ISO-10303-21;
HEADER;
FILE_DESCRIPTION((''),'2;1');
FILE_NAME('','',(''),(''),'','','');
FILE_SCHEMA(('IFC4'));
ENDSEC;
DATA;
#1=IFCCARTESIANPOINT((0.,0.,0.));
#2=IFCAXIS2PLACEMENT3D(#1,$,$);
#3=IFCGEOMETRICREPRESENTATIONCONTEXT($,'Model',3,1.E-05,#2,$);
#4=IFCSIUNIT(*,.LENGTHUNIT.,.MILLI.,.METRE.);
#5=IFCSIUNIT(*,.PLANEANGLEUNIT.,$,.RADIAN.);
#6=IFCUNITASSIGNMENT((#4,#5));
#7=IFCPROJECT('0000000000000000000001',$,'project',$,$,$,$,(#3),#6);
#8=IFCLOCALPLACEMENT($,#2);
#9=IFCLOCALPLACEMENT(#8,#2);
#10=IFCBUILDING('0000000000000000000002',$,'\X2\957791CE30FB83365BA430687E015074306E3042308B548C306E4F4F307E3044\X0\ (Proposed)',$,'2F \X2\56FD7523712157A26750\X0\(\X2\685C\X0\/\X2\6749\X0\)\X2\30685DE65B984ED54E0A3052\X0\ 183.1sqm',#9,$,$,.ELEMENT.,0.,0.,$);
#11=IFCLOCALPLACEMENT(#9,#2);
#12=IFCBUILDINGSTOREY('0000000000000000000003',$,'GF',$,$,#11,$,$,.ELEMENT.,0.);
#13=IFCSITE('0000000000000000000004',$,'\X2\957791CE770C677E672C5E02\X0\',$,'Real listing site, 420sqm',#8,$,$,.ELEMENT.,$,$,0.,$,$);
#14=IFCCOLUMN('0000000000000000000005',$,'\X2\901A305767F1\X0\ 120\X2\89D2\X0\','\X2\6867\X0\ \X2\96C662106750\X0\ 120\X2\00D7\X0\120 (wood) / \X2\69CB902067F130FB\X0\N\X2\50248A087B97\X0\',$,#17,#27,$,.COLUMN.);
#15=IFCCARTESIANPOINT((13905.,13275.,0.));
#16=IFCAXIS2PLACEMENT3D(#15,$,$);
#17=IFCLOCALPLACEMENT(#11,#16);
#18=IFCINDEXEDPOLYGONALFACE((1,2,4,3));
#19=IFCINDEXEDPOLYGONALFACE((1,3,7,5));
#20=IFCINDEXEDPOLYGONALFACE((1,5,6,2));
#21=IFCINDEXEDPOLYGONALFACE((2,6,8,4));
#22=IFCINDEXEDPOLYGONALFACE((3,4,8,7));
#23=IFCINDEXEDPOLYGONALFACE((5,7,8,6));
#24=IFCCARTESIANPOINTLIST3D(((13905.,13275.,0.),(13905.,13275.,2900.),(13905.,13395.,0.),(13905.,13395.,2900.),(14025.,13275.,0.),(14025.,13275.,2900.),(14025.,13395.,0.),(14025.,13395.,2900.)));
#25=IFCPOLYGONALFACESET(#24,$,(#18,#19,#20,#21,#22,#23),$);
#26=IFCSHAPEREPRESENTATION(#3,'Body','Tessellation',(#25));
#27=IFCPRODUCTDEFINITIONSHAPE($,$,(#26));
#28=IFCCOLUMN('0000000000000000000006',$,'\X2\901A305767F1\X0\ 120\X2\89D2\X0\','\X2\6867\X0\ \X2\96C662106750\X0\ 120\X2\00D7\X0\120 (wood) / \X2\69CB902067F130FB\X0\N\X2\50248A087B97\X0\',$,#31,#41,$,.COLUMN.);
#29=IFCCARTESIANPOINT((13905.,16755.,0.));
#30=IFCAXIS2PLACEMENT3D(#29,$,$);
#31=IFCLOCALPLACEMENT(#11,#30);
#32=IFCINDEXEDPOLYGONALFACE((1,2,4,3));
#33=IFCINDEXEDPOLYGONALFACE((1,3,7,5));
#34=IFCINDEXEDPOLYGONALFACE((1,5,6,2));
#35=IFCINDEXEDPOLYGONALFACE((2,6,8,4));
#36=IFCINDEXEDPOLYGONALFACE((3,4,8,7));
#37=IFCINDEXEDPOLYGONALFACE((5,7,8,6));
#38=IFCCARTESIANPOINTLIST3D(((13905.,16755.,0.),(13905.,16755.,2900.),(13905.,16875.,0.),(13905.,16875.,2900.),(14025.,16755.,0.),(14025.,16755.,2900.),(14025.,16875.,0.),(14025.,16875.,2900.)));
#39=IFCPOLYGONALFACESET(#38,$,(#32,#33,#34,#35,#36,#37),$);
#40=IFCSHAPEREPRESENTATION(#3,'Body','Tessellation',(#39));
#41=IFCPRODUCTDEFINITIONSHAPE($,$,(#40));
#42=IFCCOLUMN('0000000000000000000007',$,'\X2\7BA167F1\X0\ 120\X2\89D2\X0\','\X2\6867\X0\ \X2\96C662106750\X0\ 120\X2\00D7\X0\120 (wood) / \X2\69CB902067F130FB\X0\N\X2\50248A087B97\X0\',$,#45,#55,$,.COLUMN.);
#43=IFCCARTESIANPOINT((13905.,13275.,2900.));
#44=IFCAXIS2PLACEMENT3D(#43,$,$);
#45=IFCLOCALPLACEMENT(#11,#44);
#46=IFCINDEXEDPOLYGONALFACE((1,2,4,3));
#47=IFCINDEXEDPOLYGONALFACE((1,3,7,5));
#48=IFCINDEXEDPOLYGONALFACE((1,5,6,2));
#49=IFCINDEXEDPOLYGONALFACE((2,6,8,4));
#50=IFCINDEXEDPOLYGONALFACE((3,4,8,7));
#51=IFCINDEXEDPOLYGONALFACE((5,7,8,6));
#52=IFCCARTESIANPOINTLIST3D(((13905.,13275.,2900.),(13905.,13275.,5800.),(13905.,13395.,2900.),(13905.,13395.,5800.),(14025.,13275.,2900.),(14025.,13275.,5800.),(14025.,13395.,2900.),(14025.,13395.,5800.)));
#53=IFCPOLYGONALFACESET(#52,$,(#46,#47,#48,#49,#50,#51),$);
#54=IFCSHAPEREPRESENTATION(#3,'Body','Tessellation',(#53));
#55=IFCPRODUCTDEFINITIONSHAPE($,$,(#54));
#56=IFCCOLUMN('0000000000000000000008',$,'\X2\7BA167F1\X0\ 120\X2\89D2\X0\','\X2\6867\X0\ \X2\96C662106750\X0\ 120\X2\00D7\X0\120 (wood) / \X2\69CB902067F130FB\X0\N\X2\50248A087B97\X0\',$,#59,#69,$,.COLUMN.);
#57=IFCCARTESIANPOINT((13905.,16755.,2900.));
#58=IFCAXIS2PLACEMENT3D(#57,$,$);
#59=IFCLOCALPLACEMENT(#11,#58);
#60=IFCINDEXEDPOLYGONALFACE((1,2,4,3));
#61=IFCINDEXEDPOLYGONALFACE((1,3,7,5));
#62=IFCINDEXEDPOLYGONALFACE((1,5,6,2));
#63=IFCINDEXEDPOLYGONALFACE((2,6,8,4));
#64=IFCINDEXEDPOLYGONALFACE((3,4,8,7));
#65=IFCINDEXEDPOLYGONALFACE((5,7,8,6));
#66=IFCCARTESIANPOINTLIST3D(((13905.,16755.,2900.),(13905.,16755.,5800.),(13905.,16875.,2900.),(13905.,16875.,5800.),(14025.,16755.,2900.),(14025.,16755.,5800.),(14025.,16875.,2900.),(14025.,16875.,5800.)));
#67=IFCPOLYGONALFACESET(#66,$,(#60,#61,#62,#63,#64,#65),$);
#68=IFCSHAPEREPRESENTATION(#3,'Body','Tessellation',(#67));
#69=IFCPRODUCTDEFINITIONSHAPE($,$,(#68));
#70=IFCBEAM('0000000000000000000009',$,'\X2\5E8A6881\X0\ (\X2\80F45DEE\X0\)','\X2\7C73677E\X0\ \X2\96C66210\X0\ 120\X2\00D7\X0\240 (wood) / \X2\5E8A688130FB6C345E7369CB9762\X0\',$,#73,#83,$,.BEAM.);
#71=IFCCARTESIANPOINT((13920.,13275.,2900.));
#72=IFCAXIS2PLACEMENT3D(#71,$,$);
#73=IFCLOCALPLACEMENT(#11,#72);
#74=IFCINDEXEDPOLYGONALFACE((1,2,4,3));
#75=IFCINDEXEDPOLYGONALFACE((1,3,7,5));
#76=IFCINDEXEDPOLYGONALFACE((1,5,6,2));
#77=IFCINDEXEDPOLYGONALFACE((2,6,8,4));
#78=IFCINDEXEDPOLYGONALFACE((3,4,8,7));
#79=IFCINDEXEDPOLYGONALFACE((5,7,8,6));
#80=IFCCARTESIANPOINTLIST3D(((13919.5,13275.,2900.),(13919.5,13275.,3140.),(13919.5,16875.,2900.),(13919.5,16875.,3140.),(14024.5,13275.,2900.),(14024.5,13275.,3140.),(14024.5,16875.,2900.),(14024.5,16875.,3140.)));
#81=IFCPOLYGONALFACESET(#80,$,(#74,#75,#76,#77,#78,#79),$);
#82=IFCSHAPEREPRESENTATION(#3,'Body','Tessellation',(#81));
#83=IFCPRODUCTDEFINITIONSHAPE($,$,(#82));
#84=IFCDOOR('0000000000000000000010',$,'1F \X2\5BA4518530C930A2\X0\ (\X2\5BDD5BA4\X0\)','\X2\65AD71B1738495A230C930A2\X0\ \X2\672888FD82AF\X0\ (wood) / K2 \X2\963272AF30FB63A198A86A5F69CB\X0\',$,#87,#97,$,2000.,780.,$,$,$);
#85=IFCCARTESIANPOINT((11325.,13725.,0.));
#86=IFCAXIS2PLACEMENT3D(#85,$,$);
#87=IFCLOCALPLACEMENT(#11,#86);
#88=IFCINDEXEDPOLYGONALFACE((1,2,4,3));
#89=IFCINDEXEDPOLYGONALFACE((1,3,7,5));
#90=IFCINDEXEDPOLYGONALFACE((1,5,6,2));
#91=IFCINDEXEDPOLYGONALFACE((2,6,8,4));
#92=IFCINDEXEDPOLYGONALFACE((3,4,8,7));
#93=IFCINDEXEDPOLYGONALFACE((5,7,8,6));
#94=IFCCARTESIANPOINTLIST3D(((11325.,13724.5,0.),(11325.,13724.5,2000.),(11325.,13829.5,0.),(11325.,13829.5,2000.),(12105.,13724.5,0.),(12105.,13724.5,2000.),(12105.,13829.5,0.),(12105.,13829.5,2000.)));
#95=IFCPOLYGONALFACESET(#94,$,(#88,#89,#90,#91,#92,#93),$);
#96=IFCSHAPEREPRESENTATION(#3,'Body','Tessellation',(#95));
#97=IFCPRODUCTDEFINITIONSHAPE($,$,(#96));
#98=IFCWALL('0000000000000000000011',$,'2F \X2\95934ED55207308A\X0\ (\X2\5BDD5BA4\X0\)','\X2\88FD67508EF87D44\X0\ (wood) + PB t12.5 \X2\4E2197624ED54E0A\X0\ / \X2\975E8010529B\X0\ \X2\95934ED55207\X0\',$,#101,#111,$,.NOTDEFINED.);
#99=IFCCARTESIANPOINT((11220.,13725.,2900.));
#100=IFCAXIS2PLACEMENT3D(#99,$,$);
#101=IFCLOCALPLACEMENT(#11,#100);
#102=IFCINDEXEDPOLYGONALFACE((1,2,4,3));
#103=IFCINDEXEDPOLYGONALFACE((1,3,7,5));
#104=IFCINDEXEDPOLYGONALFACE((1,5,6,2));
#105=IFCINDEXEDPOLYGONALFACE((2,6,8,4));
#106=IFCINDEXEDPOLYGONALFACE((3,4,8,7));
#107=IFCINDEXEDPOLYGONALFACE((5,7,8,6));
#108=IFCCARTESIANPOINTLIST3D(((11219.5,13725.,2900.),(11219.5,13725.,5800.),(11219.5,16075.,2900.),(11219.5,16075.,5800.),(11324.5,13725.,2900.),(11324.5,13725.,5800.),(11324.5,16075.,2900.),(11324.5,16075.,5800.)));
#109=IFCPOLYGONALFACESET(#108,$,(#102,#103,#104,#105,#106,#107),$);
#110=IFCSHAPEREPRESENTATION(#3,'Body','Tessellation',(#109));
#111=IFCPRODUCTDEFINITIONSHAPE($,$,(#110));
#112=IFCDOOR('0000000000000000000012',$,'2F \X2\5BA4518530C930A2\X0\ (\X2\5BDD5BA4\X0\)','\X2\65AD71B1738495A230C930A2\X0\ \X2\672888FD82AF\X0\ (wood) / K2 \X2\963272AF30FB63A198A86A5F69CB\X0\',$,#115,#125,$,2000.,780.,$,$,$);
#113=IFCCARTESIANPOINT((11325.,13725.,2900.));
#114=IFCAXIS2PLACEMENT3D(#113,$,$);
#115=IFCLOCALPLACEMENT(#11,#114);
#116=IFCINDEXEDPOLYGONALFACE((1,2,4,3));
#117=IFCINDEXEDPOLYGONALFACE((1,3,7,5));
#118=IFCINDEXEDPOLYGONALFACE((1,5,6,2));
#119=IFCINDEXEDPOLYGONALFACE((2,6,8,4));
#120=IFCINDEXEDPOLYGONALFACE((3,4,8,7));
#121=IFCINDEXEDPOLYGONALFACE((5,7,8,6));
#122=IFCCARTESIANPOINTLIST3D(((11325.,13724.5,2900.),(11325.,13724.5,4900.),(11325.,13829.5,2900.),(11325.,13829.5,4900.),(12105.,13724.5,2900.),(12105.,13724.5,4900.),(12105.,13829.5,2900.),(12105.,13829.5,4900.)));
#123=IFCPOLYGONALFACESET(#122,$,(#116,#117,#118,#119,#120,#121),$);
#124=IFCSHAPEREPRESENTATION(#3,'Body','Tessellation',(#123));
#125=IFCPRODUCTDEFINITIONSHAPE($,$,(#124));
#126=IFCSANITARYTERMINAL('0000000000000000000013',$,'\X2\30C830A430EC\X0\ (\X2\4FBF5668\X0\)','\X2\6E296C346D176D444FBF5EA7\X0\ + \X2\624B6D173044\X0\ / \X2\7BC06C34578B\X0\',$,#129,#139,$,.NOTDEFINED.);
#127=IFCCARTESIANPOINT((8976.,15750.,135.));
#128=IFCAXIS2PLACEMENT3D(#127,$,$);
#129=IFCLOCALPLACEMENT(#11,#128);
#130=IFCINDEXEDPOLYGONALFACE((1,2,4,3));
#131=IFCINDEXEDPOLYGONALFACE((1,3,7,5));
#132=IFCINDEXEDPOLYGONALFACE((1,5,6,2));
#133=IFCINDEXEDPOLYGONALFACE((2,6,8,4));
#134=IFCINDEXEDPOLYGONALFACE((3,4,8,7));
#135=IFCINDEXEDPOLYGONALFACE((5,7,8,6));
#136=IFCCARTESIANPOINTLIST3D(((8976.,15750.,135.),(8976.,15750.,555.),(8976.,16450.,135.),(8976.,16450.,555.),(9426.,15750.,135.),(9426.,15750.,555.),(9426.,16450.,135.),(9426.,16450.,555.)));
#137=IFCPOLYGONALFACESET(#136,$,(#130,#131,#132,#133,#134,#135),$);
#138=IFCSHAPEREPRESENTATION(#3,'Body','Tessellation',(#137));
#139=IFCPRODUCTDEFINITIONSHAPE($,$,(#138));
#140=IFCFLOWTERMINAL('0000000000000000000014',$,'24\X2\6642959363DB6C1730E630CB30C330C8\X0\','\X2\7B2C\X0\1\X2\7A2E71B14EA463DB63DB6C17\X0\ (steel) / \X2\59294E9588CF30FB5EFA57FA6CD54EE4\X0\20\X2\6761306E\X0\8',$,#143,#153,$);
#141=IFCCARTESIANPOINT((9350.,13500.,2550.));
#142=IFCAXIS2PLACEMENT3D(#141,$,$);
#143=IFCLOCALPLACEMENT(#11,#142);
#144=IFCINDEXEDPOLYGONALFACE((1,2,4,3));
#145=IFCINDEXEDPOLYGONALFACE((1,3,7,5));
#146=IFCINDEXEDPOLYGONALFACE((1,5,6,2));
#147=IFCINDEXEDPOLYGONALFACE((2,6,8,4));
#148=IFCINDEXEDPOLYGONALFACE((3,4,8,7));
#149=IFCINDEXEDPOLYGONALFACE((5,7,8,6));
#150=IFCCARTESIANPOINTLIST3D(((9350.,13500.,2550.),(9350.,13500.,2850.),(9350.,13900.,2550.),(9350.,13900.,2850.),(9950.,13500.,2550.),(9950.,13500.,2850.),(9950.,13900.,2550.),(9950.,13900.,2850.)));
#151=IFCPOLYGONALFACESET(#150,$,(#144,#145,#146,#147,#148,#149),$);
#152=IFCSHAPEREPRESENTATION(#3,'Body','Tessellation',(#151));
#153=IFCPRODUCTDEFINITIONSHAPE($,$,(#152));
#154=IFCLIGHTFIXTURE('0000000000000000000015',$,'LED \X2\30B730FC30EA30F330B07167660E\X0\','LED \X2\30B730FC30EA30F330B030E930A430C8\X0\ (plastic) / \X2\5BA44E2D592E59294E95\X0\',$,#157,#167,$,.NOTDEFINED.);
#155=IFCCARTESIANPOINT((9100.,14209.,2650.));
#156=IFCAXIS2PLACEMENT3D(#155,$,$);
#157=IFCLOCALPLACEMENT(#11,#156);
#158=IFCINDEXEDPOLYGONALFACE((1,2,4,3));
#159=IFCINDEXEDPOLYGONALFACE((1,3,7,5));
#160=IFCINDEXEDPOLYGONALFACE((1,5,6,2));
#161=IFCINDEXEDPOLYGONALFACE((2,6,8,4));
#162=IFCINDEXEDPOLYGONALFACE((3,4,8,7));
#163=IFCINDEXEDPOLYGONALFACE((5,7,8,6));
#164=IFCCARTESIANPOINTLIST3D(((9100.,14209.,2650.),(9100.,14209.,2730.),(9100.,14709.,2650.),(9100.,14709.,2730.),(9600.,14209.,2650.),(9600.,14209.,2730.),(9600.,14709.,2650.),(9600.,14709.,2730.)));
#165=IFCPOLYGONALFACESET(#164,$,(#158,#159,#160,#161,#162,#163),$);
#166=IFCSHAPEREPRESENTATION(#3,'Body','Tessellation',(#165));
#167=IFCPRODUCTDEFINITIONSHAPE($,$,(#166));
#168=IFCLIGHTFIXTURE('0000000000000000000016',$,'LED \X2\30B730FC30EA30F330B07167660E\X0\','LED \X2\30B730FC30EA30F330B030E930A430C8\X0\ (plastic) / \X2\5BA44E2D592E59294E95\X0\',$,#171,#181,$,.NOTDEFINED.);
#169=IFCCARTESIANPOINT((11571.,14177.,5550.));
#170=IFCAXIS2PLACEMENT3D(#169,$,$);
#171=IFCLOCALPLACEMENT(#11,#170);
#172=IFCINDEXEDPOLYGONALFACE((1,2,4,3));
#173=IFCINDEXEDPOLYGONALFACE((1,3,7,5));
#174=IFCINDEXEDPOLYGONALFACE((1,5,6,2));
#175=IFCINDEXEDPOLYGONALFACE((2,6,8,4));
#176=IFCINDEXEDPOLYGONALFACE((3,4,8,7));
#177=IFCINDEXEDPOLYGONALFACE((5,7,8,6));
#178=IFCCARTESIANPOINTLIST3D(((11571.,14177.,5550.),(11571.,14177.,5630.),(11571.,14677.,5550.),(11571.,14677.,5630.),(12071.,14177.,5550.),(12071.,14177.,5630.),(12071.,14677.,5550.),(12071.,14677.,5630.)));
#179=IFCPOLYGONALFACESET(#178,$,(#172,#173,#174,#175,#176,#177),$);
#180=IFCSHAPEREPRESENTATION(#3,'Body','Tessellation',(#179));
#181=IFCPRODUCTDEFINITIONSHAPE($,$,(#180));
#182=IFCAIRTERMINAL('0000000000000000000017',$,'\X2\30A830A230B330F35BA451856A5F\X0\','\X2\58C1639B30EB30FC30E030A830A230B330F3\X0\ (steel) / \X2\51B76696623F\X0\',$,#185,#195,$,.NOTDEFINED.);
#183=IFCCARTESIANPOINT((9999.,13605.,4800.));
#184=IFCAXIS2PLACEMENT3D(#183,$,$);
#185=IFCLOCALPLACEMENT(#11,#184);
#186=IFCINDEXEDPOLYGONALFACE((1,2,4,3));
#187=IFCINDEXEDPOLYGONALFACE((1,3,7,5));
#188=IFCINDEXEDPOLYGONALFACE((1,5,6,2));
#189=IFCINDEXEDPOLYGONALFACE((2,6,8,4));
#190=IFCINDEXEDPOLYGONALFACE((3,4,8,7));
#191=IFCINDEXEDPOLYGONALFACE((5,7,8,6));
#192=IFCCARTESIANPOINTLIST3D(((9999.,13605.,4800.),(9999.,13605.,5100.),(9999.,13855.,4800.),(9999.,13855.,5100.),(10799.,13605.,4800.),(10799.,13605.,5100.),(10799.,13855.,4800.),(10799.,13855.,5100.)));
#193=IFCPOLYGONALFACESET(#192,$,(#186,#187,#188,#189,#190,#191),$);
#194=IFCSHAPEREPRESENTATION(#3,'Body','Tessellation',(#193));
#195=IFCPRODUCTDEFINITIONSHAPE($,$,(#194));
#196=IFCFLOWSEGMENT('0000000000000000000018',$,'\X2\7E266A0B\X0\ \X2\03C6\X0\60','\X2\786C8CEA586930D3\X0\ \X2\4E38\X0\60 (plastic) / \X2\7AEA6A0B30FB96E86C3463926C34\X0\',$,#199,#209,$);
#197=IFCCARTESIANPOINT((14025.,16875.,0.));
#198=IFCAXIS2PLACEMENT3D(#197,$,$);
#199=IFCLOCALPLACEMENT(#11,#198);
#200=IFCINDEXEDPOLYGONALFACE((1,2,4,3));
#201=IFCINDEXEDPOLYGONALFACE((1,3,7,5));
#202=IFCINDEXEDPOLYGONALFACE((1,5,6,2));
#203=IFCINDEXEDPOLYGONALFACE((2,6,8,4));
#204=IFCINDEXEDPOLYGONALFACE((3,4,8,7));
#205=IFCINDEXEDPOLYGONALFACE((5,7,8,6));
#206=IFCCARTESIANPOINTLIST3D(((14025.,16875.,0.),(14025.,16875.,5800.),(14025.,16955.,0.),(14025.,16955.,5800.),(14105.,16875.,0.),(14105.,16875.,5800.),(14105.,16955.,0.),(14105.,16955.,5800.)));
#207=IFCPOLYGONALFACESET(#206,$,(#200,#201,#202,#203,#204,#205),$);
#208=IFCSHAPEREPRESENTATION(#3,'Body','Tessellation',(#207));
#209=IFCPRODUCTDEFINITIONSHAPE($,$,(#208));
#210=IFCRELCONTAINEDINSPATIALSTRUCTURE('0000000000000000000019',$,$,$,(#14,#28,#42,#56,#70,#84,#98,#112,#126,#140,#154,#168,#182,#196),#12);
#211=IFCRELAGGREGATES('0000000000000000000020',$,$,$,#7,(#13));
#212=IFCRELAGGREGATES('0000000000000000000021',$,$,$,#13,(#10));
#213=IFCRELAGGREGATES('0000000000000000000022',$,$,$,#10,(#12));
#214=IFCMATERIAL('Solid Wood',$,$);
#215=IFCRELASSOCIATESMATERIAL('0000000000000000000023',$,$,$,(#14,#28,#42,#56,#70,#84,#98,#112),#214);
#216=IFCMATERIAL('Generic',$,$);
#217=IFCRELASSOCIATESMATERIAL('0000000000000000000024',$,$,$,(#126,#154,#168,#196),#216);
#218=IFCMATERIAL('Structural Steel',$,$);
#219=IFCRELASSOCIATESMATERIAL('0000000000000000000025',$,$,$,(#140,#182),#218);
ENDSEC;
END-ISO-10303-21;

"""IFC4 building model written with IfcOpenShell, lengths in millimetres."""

from ifc_helpers import new_model, si_unit, frame, frame_2d, origin, place, context, project, spatial, rectangle, extrude, material, element, save


model = new_model("IFC4")

# Units and contexts
model_context = context("Model", 3, precision=1e-05, world=origin())
ifc_project = project(units=[si_unit("LENGTHUNIT", "METRE", prefix="MILLI"), si_unit("PLANEANGLEUNIT", "RADIAN")], contexts=[model_context])

# Site, building, storey
site_placement = place(None, origin())
site = spatial("IfcSite", under=ifc_project, at=site_placement, Name="長野県松本市", ObjectType="Real listing site, 420sqm", CompositionType="ELEMENT", RefElevation=0.0)
building_placement = place(site_placement, origin())
building = spatial("IfcBuilding", under=site, at=building_placement, Name="長野・茶室と縁側のある和の住まい (Proposed)", ObjectType="2F 国産無垢材(桜/杉)と左官仕上げ 183.1sqm", CompositionType="ELEMENT", ElevationOfRefHeight=0.0, ElevationOfTerrain=0.0)
storey_placement = place(building_placement, origin())
storey = spatial("IfcBuildingStorey", under=building, at=storey_placement, Name="GF", CompositionType="ELEMENT", Elevation=0.0)

# Columns
ifc_material_1 = material(Name="Solid Wood")
column_1_placement = place(storey_placement, frame((13905.0, 13275.0, 0.0)))
element("IfcColumn", 1, at=column_1_placement, inside=storey, material=ifc_material_1, Name="通し柱 120角", Description="桧 集成材 120×120 (wood) / 構造柱・N値計算", PredefinedType="COLUMN", context=model_context, shape_type="SweptSolid", body=[
    extrude(rectangle(XDim=120.0, YDim=120.0, at=frame_2d((60.0, 60.0))), frame((13905.0, 13275.0, 0.0)), (0.0, 0.0, 1.0), 2900.0),
])
column_2_placement = place(storey_placement, frame((13905.0, 16755.0, 0.0)))
element("IfcColumn", 2, at=column_2_placement, inside=storey, material=ifc_material_1, Name="通し柱 120角", Description="桧 集成材 120×120 (wood) / 構造柱・N値計算", PredefinedType="COLUMN", context=model_context, shape_type="SweptSolid", body=[
    extrude(rectangle(XDim=120.0, YDim=120.0, at=frame_2d((60.0, 60.0))), frame((13905.0, 16755.0, 0.0)), (0.0, 0.0, 1.0), 2900.0),
])
column_3_placement = place(storey_placement, frame((13905.0, 13275.0, 2900.0)))
element("IfcColumn", 3, at=column_3_placement, inside=storey, material=ifc_material_1, Name="管柱 120角", Description="桧 集成材 120×120 (wood) / 構造柱・N値計算", PredefinedType="COLUMN", context=model_context, shape_type="SweptSolid", body=[
    extrude(rectangle(XDim=120.0, YDim=120.0, at=frame_2d((60.0, 60.0))), frame((13905.0, 13275.0, 2900.0)), (0.0, 0.0, 1.0), 2900.0),
])
column_4_placement = place(storey_placement, frame((13905.0, 16755.0, 2900.0)))
element("IfcColumn", 4, at=column_4_placement, inside=storey, material=ifc_material_1, Name="管柱 120角", Description="桧 集成材 120×120 (wood) / 構造柱・N値計算", PredefinedType="COLUMN", context=model_context, shape_type="SweptSolid", body=[
    extrude(rectangle(XDim=120.0, YDim=120.0, at=frame_2d((60.0, 60.0))), frame((13905.0, 16755.0, 2900.0)), (0.0, 0.0, 1.0), 2900.0),
])

# Beam
beam_1_placement = place(storey_placement, frame((13920.0, 13275.0, 2900.0)))
element("IfcBeam", 5, at=beam_1_placement, inside=storey, material=ifc_material_1, Name="床梁 (胴差)", Description="米松 集成 120×240 (wood) / 床梁・水平構面", PredefinedType="BEAM", context=model_context, shape_type="SweptSolid", body=[
    extrude(rectangle(XDim=105.0, YDim=3600.0, at=frame_2d((52.0, 1800.0))), frame((13920.0, 13275.0, 2900.0)), (0.0, 0.0, 1.0), 240.0),
])

# Door
door_1_placement = place(storey_placement, frame((11325.0, 13725.0, 0.0)))
element("IfcDoor", 6, at=door_1_placement, inside=storey, material=ifc_material_1, Name="1F 室内ドア (寝室)", Description="断熱玄関ドア 木製芯 (wood) / K2 防犯・採風機構", OverallHeight=2000.0, OverallWidth=780.0, context=model_context, shape_type="SweptSolid", body=[
    extrude(rectangle(XDim=780.0, YDim=105.0, at=frame_2d((390.0, 52.0))), frame((11325.0, 13725.0, 0.0)), (0.0, 0.0, 1.0), 2000.0),
])

# Wall
wall_1_placement = place(storey_placement, frame((11220.0, 13725.0, 2900.0)))
element("IfcWall", 7, at=wall_1_placement, inside=storey, material=ifc_material_1, Name="2F 間仕切り (寝室)", Description="製材軸組 (wood) + PB t12.5 両面仕上 / 非耐力 間仕切", PredefinedType="NOTDEFINED", context=model_context, shape_type="SweptSolid", body=[
    extrude(rectangle(XDim=105.0, YDim=2350.0, at=frame_2d((52.0, 1175.0))), frame((11220.0, 13725.0, 2900.0)), (0.0, 0.0, 1.0), 2900.0),
])

# Door
door_2_placement = place(storey_placement, frame((11325.0, 13725.0, 2900.0)))
element("IfcDoor", 8, at=door_2_placement, inside=storey, material=ifc_material_1, Name="2F 室内ドア (寝室)", Description="断熱玄関ドア 木製芯 (wood) / K2 防犯・採風機構", OverallHeight=2000.0, OverallWidth=780.0, context=model_context, shape_type="SweptSolid", body=[
    extrude(rectangle(XDim=780.0, YDim=105.0, at=frame_2d((390.0, 52.0))), frame((11325.0, 13725.0, 2900.0)), (0.0, 0.0, 1.0), 2000.0),
])

# Sanitary terminal
ifc_material_2 = material(Name="Generic")
sanitary_terminal_placement = place(storey_placement, frame((8976.0, 15750.0, 135.0)))
element("IfcSanitaryTerminal", 9, at=sanitary_terminal_placement, inside=storey, material=ifc_material_2, Name="トイレ (便器)", Description="温水洗浄便座 + 手洗い / 節水型", PredefinedType="NOTDEFINED", context=model_context, shape_type="SweptSolid", body=[
    extrude(rectangle(XDim=450.0, YDim=700.0, at=frame_2d((225.0, 350.0))), frame((8976.0, 15750.0, 135.0)), (0.0, 0.0, 1.0), 420.0),
])

# Flow terminal
ifc_material_3 = material(Name="Structural Steel")
flow_terminal_placement = place(storey_placement, frame((9350.0, 13500.0, 2550.0)))
element("IfcFlowTerminal", 10, at=flow_terminal_placement, inside=storey, material=ifc_material_3, Name="24時間換気ユニット", Description="第1種熱交換換気 (steel) / 天井裏・建基法令20条の8", context=model_context, shape_type="SweptSolid", body=[
    extrude(rectangle(XDim=600.0, YDim=400.0, at=frame_2d((300.0, 200.0))), frame((9350.0, 13500.0, 2550.0)), (0.0, 0.0, 1.0), 300.0),
])

# Light fixtures
light_fixture_1_placement = place(storey_placement, frame((9100.0, 14209.0, 2650.0)))
element("IfcLightFixture", 11, at=light_fixture_1_placement, inside=storey, material=ifc_material_2, Name="LED シーリング照明", Description="LED シーリングライト (plastic) / 室中央天井", PredefinedType="NOTDEFINED", context=model_context, shape_type="SweptSolid", body=[
    extrude(rectangle(XDim=500.0, YDim=500.0, at=frame_2d((250.0, 250.0))), frame((9100.0, 14209.0, 2650.0)), (0.0, 0.0, 1.0), 80.0),
])
light_fixture_2_placement = place(storey_placement, frame((11571.0, 14177.0, 5550.0)))
element("IfcLightFixture", 12, at=light_fixture_2_placement, inside=storey, material=ifc_material_2, Name="LED シーリング照明", Description="LED シーリングライト (plastic) / 室中央天井", PredefinedType="NOTDEFINED", context=model_context, shape_type="SweptSolid", body=[
    extrude(rectangle(XDim=500.0, YDim=500.0, at=frame_2d((250.0, 250.0))), frame((11571.0, 14177.0, 5550.0)), (0.0, 0.0, 1.0), 80.0),
])

# Air terminal
air_terminal_placement = place(storey_placement, frame((9999.0, 13605.0, 4800.0)))
element("IfcAirTerminal", 13, at=air_terminal_placement, inside=storey, material=ifc_material_3, Name="エアコン室内機", Description="壁掛ルームエアコン (steel) / 冷暖房", PredefinedType="NOTDEFINED", context=model_context, shape_type="SweptSolid", body=[
    extrude(rectangle(XDim=800.0, YDim=250.0, at=frame_2d((400.0, 125.0))), frame((9999.0, 13605.0, 4800.0)), (0.0, 0.0, 1.0), 300.0),
])

# Flow segment
flow_segment_placement = place(storey_placement, frame((14025.0, 16875.0, 0.0)))
element("IfcFlowSegment", 14, at=flow_segment_placement, inside=storey, material=ifc_material_2, Name="縦樋 φ60", Description="硬質塩ビ 丸60 (plastic) / 竪樋・雨水排水", context=model_context, shape_type="SweptSolid", body=[
    extrude(rectangle(XDim=80.0, YDim=80.0, at=frame_2d((40.0, 40.0))), frame((14025.0, 16875.0, 0.0)), (0.0, 0.0, 1.0), 5800.0),
])

save(model, "model.ifc")
